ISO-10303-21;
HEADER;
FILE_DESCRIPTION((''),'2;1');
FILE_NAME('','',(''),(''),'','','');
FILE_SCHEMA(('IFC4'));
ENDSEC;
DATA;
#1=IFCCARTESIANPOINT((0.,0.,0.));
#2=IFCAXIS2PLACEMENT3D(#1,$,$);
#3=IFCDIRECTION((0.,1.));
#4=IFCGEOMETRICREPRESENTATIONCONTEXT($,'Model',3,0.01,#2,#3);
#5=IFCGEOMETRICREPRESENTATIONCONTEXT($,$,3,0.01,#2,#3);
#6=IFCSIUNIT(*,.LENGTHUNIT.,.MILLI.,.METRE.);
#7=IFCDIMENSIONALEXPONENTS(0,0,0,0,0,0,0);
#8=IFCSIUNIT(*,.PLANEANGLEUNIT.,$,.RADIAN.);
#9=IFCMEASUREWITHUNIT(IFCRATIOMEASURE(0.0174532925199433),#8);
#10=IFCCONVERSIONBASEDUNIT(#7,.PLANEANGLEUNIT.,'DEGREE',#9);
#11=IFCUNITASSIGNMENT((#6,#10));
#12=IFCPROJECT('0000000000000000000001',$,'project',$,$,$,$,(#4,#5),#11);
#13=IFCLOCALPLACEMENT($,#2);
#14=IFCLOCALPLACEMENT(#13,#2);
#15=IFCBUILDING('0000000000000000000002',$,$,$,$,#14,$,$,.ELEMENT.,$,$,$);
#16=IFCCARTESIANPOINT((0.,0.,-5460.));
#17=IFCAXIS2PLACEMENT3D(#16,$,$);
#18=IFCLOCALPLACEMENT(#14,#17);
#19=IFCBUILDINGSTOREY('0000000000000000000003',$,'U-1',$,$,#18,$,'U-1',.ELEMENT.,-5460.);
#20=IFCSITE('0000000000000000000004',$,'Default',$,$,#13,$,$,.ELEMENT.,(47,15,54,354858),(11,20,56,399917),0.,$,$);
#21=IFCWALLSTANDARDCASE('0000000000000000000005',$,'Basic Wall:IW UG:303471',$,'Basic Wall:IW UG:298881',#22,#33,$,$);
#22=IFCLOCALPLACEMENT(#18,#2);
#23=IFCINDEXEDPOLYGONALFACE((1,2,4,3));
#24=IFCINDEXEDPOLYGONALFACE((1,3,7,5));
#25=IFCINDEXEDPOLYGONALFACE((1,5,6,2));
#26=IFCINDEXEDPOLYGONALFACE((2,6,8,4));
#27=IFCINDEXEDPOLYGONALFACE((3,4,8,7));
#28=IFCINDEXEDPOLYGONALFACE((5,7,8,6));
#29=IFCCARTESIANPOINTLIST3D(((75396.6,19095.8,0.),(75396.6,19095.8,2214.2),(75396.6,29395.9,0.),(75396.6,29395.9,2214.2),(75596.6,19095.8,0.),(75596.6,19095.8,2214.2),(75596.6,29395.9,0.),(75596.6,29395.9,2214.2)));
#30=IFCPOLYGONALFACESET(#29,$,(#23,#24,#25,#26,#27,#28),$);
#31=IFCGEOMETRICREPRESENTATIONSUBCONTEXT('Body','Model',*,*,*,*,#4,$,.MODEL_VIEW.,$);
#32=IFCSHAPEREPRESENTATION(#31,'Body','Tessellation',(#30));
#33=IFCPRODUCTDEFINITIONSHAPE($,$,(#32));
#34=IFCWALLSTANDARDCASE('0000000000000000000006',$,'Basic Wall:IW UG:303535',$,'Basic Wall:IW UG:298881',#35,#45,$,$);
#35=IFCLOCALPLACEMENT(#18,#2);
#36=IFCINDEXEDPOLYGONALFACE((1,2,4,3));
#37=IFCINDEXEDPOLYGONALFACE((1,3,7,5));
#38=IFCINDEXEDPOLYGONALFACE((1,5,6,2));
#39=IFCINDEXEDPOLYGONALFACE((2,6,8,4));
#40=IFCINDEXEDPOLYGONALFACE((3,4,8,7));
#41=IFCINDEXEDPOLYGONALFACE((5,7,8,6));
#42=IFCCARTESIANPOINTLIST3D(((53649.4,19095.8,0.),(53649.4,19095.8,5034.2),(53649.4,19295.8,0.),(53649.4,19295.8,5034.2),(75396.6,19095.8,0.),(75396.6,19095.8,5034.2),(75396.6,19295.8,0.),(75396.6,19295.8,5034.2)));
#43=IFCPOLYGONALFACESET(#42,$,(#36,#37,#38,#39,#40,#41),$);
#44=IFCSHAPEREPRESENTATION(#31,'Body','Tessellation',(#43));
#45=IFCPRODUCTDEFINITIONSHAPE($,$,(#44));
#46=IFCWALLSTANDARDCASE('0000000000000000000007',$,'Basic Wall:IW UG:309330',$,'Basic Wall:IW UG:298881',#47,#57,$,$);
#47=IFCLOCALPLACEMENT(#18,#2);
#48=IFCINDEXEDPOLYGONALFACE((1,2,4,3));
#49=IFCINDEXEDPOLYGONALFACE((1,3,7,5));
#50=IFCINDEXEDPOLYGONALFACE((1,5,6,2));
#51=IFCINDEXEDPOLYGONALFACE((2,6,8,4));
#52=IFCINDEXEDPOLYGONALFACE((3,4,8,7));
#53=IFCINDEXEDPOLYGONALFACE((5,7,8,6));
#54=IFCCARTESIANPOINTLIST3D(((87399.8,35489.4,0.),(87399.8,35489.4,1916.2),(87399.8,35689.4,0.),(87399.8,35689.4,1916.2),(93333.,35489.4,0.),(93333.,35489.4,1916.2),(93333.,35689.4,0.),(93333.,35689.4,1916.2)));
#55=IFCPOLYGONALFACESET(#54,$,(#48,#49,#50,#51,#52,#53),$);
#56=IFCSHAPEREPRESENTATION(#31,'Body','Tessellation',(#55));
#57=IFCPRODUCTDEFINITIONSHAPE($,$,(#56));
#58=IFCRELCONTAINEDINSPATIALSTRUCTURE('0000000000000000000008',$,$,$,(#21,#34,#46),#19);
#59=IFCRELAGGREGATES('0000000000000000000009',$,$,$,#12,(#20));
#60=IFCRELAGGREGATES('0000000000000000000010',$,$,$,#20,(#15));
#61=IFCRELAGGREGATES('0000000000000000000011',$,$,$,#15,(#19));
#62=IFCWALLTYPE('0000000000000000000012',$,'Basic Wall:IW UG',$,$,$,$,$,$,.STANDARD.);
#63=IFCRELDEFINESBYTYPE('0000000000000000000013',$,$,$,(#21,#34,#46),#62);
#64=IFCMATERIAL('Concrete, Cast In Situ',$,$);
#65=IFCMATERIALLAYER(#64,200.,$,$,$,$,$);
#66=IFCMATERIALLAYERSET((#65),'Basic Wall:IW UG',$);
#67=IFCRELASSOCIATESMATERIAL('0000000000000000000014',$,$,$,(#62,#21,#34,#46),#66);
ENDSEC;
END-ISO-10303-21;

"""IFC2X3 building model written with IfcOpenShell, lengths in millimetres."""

from ifc_helpers import new_model, entity, si_unit, converted_unit, direction, frame, frame_2d, origin, place, context, subcontext, project, spatial, polyline, rectangle, extrude, clip, bounded_halfspace, material, layer, layer_set, layer_usage, type_object, element, save


model = new_model("IFC2X3")

# Units and contexts
model_context = context("Model", 3, precision=0.01, world=origin(), true_north=direction((0.0, 1.0)))
context_of_model = context(None, 3, precision=0.01, world=origin(), true_north=direction((0.0, 1.0)))
body_context = subcontext(model_context, "Body", "Model", "MODEL_VIEW")
ifc_project = project(units=[si_unit("LENGTHUNIT", "METRE", prefix="MILLI"), converted_unit("PLANEANGLEUNIT", "DEGREE", entity("IfcRatioMeasure", 0.0174532925199433), si_unit("PLANEANGLEUNIT", "RADIAN"), dimensions=[0, 0, 0, 0, 0, 0, 0])], contexts=[model_context, context_of_model])

# Site, building, storey
site_placement = place(None, origin())
site = spatial("IfcSite", under=ifc_project, at=site_placement, Name="Default", CompositionType="ELEMENT", RefLatitude=(47, 15, 54, 354858), RefLongitude=(11, 20, 56, 399917), RefElevation=0.0)
building_placement = place(site_placement, origin())
building = spatial("IfcBuilding", under=site, at=building_placement, CompositionType="ELEMENT")
storey_placement = place(building_placement, frame((0.0, 0.0, -5460.0)))
storey = spatial("IfcBuildingStorey", under=building, at=storey_placement, Name="U-1", LongName="U-1", CompositionType="ELEMENT", Elevation=-5460.0)

# Walls
ifc_material_1 = material(Name="Concrete, Cast In Situ")
ifc_layer_1 = layer(ifc_material_1, 200.0)
ifc_layer_set_1 = layer_set([ifc_layer_1], Name="Basic Wall:IW UG")
wall_type_1 = type_object("IfcWallType", Name="Basic Wall:IW UG", PredefinedType="STANDARD", material=ifc_layer_set_1)
ifc_layer_usage_1 = layer_usage(ifc_layer_set_1, "AXIS2", "NEGATIVE", 100.0)
wall_1_placement = place(storey_placement, frame((75496.6, 29395.9, 0.0), z_axis=(0.0, 0.0, 1.0), x_axis=(0.0, -1.0, 0.0)))
element("IfcWallStandardCase", 1, at=wall_1_placement, inside=storey, type_object=wall_type_1, material=ifc_layer_usage_1, Name="Basic Wall:IW UG:303471", ObjectType="Basic Wall:IW UG:298881", context=body_context, shape_type="Clipping", body=[
    clip(extrude(rectangle(XDim=10300.0, YDim=200.0, at=frame_2d((5150.0, 0.0), x_axis=(-1.0, 0.0))), origin(), (0.0, 0.0, 1.0), 2214.2), bounded_halfspace(frame((0.0, -100.0, 2214.2), z_axis=(0.0, 0.0, -1.0), x_axis=(0.0, 1.0, 0.0)), True, frame((0.0, -100.0, 2214.2)), polyline([(0.0, 0.0), (10300.0, 0.0), (10300.0, 200.0), (0.0, 200.0), (0.0, 0.0)]))),
])
ifc_layer_usage_2 = layer_usage(ifc_layer_set_1, "AXIS2", "NEGATIVE", 100.0)
wall_2_placement = place(storey_placement, frame((75396.6, 19195.8, 0.0), z_axis=(0.0, 0.0, 1.0), x_axis=(-1.0, 0.0, 0.0)))
element("IfcWallStandardCase", 2, at=wall_2_placement, inside=storey, type_object=wall_type_1, material=ifc_layer_usage_2, Name="Basic Wall:IW UG:303535", ObjectType="Basic Wall:IW UG:298881", context=body_context, shape_type="Clipping", body=[
    clip(extrude(rectangle(XDim=21747.2, YDim=200.0, at=frame_2d((10873.6, 0.0), x_axis=(-1.0, 0.0))), origin(), (0.0, 0.0, 1.0), 5034.2), bounded_halfspace(frame((0.0, -100.0, 5034.2), z_axis=(0.0, 0.0, -1.0), x_axis=(-1.0, 0.0, 0.0)), True, frame((0.0, -100.0, 5034.2)), polyline([(0.0, 0.0), (12500.0, 0.0), (12700.0, 0.0), (21547.2, 0.0), (21747.2, 0.0), (21747.2, 200.0), (0.0, 200.0), (0.0, 0.0)]))),
])
ifc_layer_usage_3 = layer_usage(ifc_layer_set_1, "AXIS2", "NEGATIVE", 100.0)
wall_3_placement = place(storey_placement, frame((87399.8, 35589.4, 0.0)))
element("IfcWallStandardCase", 3, at=wall_3_placement, inside=storey, type_object=wall_type_1, material=ifc_layer_usage_3, Name="Basic Wall:IW UG:309330", ObjectType="Basic Wall:IW UG:298881", context=body_context, shape_type="SweptSolid", body=[
    extrude(rectangle(XDim=5933.2, YDim=200.0, at=frame_2d((2966.6, 0.0), x_axis=(-1.0, 0.0))), origin(), (0.0, 0.0, 1.0), 1916.2),
])

save(model, "model.ifc")
